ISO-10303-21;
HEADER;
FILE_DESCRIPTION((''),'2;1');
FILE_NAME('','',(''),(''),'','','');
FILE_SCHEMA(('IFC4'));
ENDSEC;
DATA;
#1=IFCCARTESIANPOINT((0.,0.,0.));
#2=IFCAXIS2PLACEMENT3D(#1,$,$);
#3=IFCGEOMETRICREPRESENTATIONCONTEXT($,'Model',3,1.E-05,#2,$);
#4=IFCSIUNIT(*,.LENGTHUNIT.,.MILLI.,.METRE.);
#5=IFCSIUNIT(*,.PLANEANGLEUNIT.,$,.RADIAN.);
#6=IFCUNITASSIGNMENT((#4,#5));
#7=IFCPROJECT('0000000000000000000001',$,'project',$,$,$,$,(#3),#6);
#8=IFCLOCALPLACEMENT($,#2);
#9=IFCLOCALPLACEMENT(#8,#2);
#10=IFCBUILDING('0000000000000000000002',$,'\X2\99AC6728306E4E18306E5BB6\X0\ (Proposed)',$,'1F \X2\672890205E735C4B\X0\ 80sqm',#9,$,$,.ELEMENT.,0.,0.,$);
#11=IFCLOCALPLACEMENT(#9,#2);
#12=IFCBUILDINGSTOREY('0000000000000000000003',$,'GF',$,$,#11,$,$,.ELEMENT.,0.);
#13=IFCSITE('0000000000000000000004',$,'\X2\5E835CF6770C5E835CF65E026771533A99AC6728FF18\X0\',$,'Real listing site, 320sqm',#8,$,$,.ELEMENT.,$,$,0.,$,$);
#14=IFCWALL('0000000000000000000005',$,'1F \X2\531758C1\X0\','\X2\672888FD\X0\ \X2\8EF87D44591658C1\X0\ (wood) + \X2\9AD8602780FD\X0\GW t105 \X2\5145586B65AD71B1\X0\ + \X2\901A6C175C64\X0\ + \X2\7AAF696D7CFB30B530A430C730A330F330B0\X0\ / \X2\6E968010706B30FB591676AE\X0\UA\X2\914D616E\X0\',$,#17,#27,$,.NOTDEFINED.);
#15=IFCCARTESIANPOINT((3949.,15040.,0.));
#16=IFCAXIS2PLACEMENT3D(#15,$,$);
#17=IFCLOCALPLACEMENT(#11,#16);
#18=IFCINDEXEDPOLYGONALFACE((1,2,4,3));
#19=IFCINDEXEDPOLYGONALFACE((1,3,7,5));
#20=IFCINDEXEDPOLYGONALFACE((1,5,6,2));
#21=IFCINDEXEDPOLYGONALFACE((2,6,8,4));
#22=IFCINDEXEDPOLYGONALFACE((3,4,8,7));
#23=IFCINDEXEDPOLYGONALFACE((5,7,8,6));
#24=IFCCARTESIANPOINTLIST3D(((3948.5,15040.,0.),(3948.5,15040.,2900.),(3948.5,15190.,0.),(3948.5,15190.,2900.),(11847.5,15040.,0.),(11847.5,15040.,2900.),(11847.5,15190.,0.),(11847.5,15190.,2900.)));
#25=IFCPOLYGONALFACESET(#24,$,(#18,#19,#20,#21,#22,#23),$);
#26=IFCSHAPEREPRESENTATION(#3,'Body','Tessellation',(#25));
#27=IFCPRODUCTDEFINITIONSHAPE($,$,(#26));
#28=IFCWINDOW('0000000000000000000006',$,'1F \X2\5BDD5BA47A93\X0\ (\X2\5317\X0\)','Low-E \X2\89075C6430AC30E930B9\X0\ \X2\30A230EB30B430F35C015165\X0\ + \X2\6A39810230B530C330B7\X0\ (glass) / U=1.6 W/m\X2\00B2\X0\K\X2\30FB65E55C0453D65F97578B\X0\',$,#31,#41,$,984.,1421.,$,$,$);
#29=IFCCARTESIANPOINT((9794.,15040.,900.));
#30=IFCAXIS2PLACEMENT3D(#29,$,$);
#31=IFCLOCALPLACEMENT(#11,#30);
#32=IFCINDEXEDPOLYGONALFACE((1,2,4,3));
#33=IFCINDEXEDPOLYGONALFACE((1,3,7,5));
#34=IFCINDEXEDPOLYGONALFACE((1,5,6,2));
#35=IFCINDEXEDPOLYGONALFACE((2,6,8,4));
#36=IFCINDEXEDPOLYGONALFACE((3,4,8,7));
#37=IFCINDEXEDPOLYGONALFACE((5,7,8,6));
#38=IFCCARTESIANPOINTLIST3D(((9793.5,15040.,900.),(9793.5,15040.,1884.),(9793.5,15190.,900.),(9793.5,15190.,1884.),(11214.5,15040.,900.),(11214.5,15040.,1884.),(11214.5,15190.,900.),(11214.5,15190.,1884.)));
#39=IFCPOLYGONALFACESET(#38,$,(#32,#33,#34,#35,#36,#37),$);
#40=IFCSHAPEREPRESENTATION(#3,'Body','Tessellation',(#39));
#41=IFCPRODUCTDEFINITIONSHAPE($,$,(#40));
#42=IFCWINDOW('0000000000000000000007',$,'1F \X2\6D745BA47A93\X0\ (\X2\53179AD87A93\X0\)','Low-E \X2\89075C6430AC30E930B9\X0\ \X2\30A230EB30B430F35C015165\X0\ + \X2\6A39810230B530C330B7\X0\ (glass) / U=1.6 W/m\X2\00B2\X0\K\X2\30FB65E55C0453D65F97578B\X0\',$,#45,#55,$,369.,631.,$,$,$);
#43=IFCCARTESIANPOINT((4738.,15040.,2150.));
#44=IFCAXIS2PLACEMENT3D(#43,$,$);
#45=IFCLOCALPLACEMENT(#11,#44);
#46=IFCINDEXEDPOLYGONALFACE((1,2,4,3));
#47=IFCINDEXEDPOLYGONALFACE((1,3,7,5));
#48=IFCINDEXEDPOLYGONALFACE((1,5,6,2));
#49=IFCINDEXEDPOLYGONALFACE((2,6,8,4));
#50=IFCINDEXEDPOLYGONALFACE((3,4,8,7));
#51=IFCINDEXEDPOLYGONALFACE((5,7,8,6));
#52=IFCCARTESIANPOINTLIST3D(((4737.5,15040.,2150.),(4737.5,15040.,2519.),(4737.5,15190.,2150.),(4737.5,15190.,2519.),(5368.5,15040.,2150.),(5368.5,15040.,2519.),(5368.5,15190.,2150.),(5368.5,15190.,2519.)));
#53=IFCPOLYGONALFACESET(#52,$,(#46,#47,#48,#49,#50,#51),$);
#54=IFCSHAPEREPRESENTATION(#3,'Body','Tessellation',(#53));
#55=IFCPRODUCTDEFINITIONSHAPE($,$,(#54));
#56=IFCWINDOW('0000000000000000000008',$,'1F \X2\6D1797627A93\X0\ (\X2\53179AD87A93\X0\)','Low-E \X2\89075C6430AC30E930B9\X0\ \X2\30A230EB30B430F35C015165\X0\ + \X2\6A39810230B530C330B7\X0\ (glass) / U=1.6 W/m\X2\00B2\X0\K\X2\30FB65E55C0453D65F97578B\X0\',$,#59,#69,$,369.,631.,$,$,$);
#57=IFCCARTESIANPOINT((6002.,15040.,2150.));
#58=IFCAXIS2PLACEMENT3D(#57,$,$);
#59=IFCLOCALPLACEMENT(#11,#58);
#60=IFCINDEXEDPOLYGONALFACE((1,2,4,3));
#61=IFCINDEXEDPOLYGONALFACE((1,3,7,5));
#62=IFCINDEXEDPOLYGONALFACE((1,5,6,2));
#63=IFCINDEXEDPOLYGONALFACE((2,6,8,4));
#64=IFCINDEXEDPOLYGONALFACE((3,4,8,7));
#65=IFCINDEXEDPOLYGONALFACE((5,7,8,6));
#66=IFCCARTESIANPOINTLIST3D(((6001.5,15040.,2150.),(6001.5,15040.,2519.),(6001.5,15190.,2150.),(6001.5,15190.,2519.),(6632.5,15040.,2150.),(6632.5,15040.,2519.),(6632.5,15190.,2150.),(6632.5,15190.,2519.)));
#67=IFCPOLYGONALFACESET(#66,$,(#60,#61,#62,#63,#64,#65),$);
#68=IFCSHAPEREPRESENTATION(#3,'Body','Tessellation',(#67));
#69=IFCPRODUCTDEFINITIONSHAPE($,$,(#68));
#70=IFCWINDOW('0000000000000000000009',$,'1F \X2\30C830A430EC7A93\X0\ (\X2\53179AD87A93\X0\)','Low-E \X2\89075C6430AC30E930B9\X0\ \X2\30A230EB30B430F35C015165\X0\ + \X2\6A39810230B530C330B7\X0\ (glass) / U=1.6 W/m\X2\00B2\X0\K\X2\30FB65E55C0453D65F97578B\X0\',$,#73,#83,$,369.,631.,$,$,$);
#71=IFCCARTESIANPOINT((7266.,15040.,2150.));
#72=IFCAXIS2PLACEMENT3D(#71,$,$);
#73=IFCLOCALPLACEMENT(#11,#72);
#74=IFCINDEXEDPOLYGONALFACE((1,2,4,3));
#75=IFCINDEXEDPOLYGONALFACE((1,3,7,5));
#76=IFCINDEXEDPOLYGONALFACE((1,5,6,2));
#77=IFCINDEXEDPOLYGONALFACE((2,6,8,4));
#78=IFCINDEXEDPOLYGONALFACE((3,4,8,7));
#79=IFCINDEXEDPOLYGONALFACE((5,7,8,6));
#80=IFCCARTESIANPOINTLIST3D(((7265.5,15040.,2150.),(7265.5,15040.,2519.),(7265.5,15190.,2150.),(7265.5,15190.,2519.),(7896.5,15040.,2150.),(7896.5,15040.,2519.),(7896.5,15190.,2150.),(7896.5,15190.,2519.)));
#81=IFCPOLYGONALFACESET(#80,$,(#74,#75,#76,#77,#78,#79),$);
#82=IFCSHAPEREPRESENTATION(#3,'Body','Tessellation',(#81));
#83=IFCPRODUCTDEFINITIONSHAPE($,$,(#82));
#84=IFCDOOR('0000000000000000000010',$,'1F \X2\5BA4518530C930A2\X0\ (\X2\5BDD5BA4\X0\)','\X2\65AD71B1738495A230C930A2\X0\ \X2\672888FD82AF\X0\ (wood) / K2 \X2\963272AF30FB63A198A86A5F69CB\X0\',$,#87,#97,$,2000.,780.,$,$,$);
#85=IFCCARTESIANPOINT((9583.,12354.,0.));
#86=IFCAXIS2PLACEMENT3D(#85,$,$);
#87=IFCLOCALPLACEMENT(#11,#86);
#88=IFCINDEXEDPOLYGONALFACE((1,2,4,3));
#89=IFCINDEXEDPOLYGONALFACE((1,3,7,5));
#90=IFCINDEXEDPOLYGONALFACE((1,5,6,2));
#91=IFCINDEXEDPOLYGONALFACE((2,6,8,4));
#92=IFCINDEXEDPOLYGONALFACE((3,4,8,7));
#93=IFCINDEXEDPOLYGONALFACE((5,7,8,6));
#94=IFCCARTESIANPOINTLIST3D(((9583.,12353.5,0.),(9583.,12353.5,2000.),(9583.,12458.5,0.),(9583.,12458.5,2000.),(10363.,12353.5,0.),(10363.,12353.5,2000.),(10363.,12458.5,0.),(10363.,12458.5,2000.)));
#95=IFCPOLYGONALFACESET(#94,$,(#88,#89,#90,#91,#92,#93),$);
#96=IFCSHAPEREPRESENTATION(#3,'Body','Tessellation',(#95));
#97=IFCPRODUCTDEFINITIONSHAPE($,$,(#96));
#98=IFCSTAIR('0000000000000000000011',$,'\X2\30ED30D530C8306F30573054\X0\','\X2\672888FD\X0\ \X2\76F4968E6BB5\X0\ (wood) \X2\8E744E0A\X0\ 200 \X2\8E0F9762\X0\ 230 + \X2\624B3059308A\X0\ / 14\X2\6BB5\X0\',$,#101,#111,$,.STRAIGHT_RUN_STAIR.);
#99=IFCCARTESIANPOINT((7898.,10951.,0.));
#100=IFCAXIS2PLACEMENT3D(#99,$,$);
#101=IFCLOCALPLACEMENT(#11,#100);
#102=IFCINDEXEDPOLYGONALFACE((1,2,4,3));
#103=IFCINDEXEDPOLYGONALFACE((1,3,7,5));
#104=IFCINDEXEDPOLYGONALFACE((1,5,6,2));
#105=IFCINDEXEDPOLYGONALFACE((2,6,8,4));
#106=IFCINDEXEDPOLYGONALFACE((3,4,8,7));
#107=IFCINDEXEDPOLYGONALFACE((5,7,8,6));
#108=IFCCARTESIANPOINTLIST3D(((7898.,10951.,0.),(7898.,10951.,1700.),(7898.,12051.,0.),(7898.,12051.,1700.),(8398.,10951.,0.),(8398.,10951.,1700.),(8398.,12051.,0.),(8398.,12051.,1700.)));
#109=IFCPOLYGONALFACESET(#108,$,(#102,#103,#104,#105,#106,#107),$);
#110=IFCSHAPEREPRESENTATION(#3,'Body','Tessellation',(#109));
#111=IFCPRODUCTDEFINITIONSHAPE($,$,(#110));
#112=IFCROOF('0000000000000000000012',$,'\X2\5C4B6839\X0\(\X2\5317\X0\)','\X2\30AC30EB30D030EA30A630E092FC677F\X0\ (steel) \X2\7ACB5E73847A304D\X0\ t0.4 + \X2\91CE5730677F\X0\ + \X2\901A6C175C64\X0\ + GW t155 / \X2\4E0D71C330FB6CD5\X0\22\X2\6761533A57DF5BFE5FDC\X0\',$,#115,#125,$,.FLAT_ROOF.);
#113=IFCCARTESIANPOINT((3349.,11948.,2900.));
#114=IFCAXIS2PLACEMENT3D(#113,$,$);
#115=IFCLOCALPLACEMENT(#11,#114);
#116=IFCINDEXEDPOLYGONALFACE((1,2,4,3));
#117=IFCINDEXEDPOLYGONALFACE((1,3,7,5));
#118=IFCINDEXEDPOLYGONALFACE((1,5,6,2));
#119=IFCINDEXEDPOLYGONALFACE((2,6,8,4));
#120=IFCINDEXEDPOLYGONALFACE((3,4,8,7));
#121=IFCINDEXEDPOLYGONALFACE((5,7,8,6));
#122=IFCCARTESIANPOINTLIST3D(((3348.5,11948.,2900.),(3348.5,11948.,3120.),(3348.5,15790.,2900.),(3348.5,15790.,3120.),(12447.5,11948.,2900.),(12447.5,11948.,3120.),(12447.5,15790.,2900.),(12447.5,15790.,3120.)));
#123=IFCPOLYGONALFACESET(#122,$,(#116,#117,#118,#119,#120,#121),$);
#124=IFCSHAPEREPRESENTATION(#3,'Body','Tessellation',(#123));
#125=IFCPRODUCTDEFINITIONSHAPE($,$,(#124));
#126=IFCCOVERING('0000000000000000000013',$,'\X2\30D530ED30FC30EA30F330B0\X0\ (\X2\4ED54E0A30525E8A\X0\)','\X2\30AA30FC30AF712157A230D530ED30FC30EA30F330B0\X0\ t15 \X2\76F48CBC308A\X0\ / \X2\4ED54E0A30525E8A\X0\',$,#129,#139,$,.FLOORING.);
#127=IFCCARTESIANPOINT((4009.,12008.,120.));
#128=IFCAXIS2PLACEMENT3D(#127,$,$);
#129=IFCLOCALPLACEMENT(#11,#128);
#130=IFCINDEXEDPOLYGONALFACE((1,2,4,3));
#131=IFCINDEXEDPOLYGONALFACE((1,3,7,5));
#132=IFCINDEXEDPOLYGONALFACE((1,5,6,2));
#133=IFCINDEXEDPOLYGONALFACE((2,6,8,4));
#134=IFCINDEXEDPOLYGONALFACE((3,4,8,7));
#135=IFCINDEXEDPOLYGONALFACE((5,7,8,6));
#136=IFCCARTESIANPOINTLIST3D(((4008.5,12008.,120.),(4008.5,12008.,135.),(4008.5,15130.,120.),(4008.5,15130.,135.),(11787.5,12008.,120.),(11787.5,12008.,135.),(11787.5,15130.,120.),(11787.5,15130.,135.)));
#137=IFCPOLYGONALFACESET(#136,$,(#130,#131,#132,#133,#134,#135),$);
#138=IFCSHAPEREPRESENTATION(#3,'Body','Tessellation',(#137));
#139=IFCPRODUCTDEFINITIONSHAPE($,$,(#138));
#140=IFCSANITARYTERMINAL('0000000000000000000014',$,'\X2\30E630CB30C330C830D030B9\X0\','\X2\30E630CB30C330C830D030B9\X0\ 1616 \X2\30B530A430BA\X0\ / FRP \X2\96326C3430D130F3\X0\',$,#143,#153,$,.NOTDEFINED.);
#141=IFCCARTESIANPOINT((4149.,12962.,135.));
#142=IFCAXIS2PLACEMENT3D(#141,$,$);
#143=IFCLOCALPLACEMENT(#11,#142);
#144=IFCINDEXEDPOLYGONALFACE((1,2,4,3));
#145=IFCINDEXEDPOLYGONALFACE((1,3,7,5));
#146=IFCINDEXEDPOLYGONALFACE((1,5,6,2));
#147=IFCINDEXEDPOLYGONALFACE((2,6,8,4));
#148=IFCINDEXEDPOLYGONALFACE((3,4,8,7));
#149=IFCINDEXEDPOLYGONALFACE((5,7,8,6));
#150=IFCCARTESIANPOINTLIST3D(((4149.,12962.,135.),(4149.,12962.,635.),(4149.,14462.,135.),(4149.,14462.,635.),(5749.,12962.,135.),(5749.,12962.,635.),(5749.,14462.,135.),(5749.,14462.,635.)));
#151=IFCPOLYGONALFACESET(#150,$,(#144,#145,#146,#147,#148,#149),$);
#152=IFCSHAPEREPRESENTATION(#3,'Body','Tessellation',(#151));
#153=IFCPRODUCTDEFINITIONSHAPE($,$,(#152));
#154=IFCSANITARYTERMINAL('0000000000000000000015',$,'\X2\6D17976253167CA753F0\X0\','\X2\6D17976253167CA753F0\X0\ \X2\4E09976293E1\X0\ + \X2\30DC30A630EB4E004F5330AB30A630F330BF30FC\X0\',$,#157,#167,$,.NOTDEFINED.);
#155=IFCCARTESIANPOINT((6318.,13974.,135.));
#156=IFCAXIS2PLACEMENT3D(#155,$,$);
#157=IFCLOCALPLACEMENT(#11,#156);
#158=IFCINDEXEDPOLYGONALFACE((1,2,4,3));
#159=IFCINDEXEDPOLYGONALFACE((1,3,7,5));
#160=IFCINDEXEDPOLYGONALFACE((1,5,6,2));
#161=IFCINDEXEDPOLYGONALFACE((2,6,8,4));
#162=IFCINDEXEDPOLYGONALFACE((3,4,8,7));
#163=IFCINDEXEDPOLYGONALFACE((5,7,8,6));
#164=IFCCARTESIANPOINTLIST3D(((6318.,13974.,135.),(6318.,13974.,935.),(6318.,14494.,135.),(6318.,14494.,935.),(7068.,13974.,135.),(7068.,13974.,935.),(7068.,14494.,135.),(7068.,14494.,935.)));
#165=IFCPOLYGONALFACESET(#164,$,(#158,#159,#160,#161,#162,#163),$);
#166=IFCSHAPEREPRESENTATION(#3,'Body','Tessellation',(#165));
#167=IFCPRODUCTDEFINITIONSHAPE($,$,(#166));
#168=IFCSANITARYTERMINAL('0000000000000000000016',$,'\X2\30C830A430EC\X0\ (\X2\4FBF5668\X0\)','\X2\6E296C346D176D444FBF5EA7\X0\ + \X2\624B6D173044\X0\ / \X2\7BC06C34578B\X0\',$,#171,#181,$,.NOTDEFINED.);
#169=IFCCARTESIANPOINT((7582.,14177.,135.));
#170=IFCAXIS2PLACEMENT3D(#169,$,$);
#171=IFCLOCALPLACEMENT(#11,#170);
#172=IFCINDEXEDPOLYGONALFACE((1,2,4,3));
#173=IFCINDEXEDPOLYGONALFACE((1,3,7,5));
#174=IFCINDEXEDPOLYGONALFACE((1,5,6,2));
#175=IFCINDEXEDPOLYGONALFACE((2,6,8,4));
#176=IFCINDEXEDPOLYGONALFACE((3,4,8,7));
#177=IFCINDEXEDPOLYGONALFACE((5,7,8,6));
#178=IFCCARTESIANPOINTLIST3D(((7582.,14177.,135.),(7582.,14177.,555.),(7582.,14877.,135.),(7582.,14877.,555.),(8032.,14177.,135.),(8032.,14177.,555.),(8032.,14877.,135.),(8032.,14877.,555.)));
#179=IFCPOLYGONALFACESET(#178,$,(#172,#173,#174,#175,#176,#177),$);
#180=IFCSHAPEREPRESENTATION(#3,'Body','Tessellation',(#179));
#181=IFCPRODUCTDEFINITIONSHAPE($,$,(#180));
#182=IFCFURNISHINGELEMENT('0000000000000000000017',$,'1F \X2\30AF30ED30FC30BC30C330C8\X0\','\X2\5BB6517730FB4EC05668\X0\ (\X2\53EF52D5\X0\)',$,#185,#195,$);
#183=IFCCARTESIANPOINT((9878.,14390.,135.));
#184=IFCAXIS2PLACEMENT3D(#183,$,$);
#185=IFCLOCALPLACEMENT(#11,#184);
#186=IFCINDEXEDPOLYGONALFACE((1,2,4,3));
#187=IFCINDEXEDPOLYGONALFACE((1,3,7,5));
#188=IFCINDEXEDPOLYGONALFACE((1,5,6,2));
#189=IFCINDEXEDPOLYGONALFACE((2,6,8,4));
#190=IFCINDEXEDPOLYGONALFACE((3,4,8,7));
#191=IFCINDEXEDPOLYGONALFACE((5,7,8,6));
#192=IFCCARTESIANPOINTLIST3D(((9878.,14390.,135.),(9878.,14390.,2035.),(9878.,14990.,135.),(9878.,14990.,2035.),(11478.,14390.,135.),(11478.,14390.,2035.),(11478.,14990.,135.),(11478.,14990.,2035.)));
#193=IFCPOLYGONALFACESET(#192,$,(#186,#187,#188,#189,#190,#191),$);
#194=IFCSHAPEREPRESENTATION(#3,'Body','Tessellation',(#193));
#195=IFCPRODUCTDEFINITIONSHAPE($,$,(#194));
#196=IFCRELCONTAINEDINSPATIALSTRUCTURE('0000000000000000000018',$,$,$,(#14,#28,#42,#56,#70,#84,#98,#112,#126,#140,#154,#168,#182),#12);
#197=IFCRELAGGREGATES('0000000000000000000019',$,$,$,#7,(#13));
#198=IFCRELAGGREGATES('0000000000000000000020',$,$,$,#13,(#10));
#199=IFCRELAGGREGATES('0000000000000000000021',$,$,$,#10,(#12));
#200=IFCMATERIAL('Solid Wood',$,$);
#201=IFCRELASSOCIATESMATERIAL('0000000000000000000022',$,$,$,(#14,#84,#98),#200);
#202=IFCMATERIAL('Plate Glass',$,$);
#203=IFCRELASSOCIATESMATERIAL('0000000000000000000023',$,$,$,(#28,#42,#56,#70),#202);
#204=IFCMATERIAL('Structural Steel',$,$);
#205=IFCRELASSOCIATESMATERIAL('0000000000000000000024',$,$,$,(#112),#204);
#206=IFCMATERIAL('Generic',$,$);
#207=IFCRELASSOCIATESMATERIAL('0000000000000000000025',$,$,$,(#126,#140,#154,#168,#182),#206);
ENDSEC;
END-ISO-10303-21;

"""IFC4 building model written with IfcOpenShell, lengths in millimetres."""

from ifc_helpers import new_model, si_unit, frame, frame_2d, origin, place, context, project, spatial, rectangle, extrude, material, element, fill, save


model = new_model("IFC4")

# Units and contexts
model_context = context("Model", 3, precision=1e-05, world=origin())
ifc_project = project(units=[si_unit("LENGTHUNIT", "METRE", prefix="MILLI"), si_unit("PLANEANGLEUNIT", "RADIAN")], contexts=[model_context])

# Site, building, storey
site_placement = place(None, origin())
site = spatial("IfcSite", under=ifc_project, at=site_placement, Name="広島県広島市東区馬木８", ObjectType="Real listing site, 320sqm", CompositionType="ELEMENT", RefElevation=0.0)
building_placement = place(site_placement, origin())
building = spatial("IfcBuilding", under=site, at=building_placement, Name="馬木の丘の家 (Proposed)", ObjectType="1F 木造平屋 80sqm", CompositionType="ELEMENT", ElevationOfRefHeight=0.0, ElevationOfTerrain=0.0)
storey_placement = place(building_placement, origin())
storey = spatial("IfcBuildingStorey", under=building, at=storey_placement, Name="GF", CompositionType="ELEMENT", Elevation=0.0)

# Shared definitions
ifc_material_1 = material(Name="Solid Wood")

# Wall, openings, windows
wall_1_placement = place(storey_placement, frame((3949.0, 15040.0, 0.0)))
wall_1 = element("IfcWall", 1, at=wall_1_placement, inside=storey, material=ifc_material_1, Name="1F 北壁", Description="木製 軸組外壁 (wood) + 高性能GW t105 充填断熱 + 通気層 + 窯業系サイディング / 準耐火・外皮UA配慮", PredefinedType="NOTDEFINED", context=model_context, shape_type="SweptSolid", body=[
    extrude(rectangle(XDim=7899.0, YDim=150.0, at=frame_2d((3949.0, 75.0))), frame((3949.0, 15040.0, 0.0)), (0.0, 0.0, 1.0), 2900.0),
])
opening_1_placement = place(storey_placement, frame((9794.0, 15040.0, 900.0)))
opening_1 = element("IfcOpeningElement", 2, at=opening_1_placement, cuts=wall_1, PredefinedType="NOTDEFINED", context=model_context, shape_type="SweptSolid", body=[
    extrude(rectangle(XDim=1421.0, YDim=150.0, at=frame_2d((710.0, 75.0))), frame((9794.0, 15040.0, 900.0)), (0.0, 0.0, 1.0), 984.0),
])
opening_2_placement = place(storey_placement, frame((4738.0, 15040.0, 2150.0)))
opening_2 = element("IfcOpeningElement", 3, at=opening_2_placement, cuts=wall_1, PredefinedType="NOTDEFINED", context=model_context, shape_type="SweptSolid", body=[
    extrude(rectangle(XDim=631.0, YDim=150.0, at=frame_2d((315.0, 75.0))), frame((4738.0, 15040.0, 2150.0)), (0.0, 0.0, 1.0), 369.0),
])
opening_3_placement = place(storey_placement, frame((6002.0, 15040.0, 2150.0)))
opening_3 = element("IfcOpeningElement", 4, at=opening_3_placement, cuts=wall_1, PredefinedType="NOTDEFINED", context=model_context, shape_type="SweptSolid", body=[
    extrude(rectangle(XDim=631.0, YDim=150.0, at=frame_2d((315.0, 75.0))), frame((6002.0, 15040.0, 2150.0)), (0.0, 0.0, 1.0), 369.0),
])
opening_4_placement = place(storey_placement, frame((7266.0, 15040.0, 2150.0)))
opening_4 = element("IfcOpeningElement", 5, at=opening_4_placement, cuts=wall_1, PredefinedType="NOTDEFINED", context=model_context, shape_type="SweptSolid", body=[
    extrude(rectangle(XDim=631.0, YDim=150.0, at=frame_2d((315.0, 75.0))), frame((7266.0, 15040.0, 2150.0)), (0.0, 0.0, 1.0), 369.0),
])
ifc_material_2 = material(Name="Plate Glass")
window_1_placement = place(storey_placement, frame((9794.0, 15040.0, 900.0)))
window_1 = element("IfcWindow", 6, at=window_1_placement, inside=storey, material=ifc_material_2, Name="1F 寝室窓 (北)", Description="Low-E 複層ガラス アルゴン封入 + 樹脂サッシ (glass) / U=1.6 W/m²K・日射取得型", OverallHeight=984.0, OverallWidth=1421.0, context=model_context, shape_type="SweptSolid", body=[
    extrude(rectangle(XDim=1421.0, YDim=150.0, at=frame_2d((710.0, 75.0))), frame((9794.0, 15040.0, 900.0)), (0.0, 0.0, 1.0), 984.0),
])
fill(opening_1, window_1)
window_2_placement = place(storey_placement, frame((4738.0, 15040.0, 2150.0)))
window_2 = element("IfcWindow", 7, at=window_2_placement, inside=storey, material=ifc_material_2, Name="1F 浴室窓 (北高窓)", Description="Low-E 複層ガラス アルゴン封入 + 樹脂サッシ (glass) / U=1.6 W/m²K・日射取得型", OverallHeight=369.0, OverallWidth=631.0, context=model_context, shape_type="SweptSolid", body=[
    extrude(rectangle(XDim=631.0, YDim=150.0, at=frame_2d((315.0, 75.0))), frame((4738.0, 15040.0, 2150.0)), (0.0, 0.0, 1.0), 369.0),
])
fill(opening_2, window_2)
window_3_placement = place(storey_placement, frame((6002.0, 15040.0, 2150.0)))
window_3 = element("IfcWindow", 8, at=window_3_placement, inside=storey, material=ifc_material_2, Name="1F 洗面窓 (北高窓)", Description="Low-E 複層ガラス アルゴン封入 + 樹脂サッシ (glass) / U=1.6 W/m²K・日射取得型", OverallHeight=369.0, OverallWidth=631.0, context=model_context, shape_type="SweptSolid", body=[
    extrude(rectangle(XDim=631.0, YDim=150.0, at=frame_2d((315.0, 75.0))), frame((6002.0, 15040.0, 2150.0)), (0.0, 0.0, 1.0), 369.0),
])
fill(opening_3, window_3)
window_4_placement = place(storey_placement, frame((7266.0, 15040.0, 2150.0)))
window_4 = element("IfcWindow", 9, at=window_4_placement, inside=storey, material=ifc_material_2, Name="1F トイレ窓 (北高窓)", Description="Low-E 複層ガラス アルゴン封入 + 樹脂サッシ (glass) / U=1.6 W/m²K・日射取得型", OverallHeight=369.0, OverallWidth=631.0, context=model_context, shape_type="SweptSolid", body=[
    extrude(rectangle(XDim=631.0, YDim=150.0, at=frame_2d((315.0, 75.0))), frame((7266.0, 15040.0, 2150.0)), (0.0, 0.0, 1.0), 369.0),
])
fill(opening_4, window_4)

# Door
door_1_placement = place(storey_placement, frame((9583.0, 12354.0, 0.0)))
element("IfcDoor", 10, at=door_1_placement, inside=storey, material=ifc_material_1, Name="1F 室内ドア (寝室)", Description="断熱玄関ドア 木製芯 (wood) / K2 防犯・採風機構", OverallHeight=2000.0, OverallWidth=780.0, context=model_context, shape_type="SweptSolid", body=[
    extrude(rectangle(XDim=780.0, YDim=105.0, at=frame_2d((390.0, 52.0))), frame((9583.0, 12354.0, 0.0)), (0.0, 0.0, 1.0), 2000.0),
])

# Stair
stair_placement = place(storey_placement, frame((7898.0, 10951.0, 0.0)))
element("IfcStair", 11, at=stair_placement, inside=storey, material=ifc_material_1, Name="ロフトはしご", Description="木製 直階段 (wood) 蹴上 200 踏面 230 + 手すり / 14段", PredefinedType="STRAIGHT_RUN_STAIR", context=model_context, shape_type="SweptSolid", body=[
    extrude(rectangle(XDim=500.0, YDim=1100.0, at=frame_2d((250.0, 550.0))), frame((7898.0, 10951.0, 0.0)), (0.0, 0.0, 1.0), 1700.0),
])

# Roof
ifc_material_3 = material(Name="Structural Steel")
roof_1_placement = place(storey_placement, frame((3349.0, 11948.0, 2900.0)))
element("IfcRoof", 12, at=roof_1_placement, inside=storey, material=ifc_material_3, Name="屋根(北)", Description="ガルバリウム鋼板 (steel) 立平葺き t0.4 + 野地板 + 通気層 + GW t155 / 不燃・法22条区域対応", PredefinedType="FLAT_ROOF", context=model_context, shape_type="SweptSolid", body=[
    extrude(rectangle(XDim=9099.0, YDim=3842.0, at=frame_2d((4549.0, 1921.0))), frame((3349.0, 11948.0, 2900.0)), (0.0, 0.0, 1.0), 220.0),
])

# Covering
ifc_material_4 = material(Name="Generic")
covering_1_placement = place(storey_placement, frame((4009.0, 12008.0, 120.0)))
element("IfcCovering", 13, at=covering_1_placement, inside=storey, material=ifc_material_4, Name="フローリング (仕上げ床)", Description="オーク無垢フローリング t15 直貼り / 仕上げ床", PredefinedType="FLOORING", context=model_context, shape_type="SweptSolid", body=[
    extrude(rectangle(XDim=7779.0, YDim=3122.0, at=frame_2d((3889.0, 1561.0))), frame((4009.0, 12008.0, 120.0)), (0.0, 0.0, 1.0), 15.0),
])

# Sanitary terminals
sanitary_terminal_1_placement = place(storey_placement, frame((4149.0, 12962.0, 135.0)))
element("IfcSanitaryTerminal", 14, at=sanitary_terminal_1_placement, inside=storey, material=ifc_material_4, Name="ユニットバス", Description="ユニットバス 1616 サイズ / FRP 防水パン", PredefinedType="NOTDEFINED", context=model_context, shape_type="SweptSolid", body=[
    extrude(rectangle(XDim=1600.0, YDim=1500.0, at=frame_2d((800.0, 750.0))), frame((4149.0, 12962.0, 135.0)), (0.0, 0.0, 1.0), 500.0),
])
sanitary_terminal_2_placement = place(storey_placement, frame((6318.0, 13974.0, 135.0)))
element("IfcSanitaryTerminal", 15, at=sanitary_terminal_2_placement, inside=storey, material=ifc_material_4, Name="洗面化粧台", Description="洗面化粧台 三面鏡 + ボウル一体カウンター", PredefinedType="NOTDEFINED", context=model_context, shape_type="SweptSolid", body=[
    extrude(rectangle(XDim=750.0, YDim=520.0, at=frame_2d((375.0, 260.0))), frame((6318.0, 13974.0, 135.0)), (0.0, 0.0, 1.0), 800.0),
])
sanitary_terminal_3_placement = place(storey_placement, frame((7582.0, 14177.0, 135.0)))
element("IfcSanitaryTerminal", 16, at=sanitary_terminal_3_placement, inside=storey, material=ifc_material_4, Name="トイレ (便器)", Description="温水洗浄便座 + 手洗い / 節水型", PredefinedType="NOTDEFINED", context=model_context, shape_type="SweptSolid", body=[
    extrude(rectangle(XDim=450.0, YDim=700.0, at=frame_2d((225.0, 350.0))), frame((7582.0, 14177.0, 135.0)), (0.0, 0.0, 1.0), 420.0),
])

# Furnishing element
furnishing_placement = place(storey_placement, frame((9878.0, 14390.0, 135.0)))
element("IfcFurnishingElement", 17, at=furnishing_placement, inside=storey, material=ifc_material_4, Name="1F クローゼット", Description="家具・什器 (可動)", context=model_context, shape_type="SweptSolid", body=[
    extrude(rectangle(XDim=1600.0, YDim=600.0, at=frame_2d((800.0, 300.0))), frame((9878.0, 14390.0, 135.0)), (0.0, 0.0, 1.0), 1900.0),
])

save(model, "model.ifc")
